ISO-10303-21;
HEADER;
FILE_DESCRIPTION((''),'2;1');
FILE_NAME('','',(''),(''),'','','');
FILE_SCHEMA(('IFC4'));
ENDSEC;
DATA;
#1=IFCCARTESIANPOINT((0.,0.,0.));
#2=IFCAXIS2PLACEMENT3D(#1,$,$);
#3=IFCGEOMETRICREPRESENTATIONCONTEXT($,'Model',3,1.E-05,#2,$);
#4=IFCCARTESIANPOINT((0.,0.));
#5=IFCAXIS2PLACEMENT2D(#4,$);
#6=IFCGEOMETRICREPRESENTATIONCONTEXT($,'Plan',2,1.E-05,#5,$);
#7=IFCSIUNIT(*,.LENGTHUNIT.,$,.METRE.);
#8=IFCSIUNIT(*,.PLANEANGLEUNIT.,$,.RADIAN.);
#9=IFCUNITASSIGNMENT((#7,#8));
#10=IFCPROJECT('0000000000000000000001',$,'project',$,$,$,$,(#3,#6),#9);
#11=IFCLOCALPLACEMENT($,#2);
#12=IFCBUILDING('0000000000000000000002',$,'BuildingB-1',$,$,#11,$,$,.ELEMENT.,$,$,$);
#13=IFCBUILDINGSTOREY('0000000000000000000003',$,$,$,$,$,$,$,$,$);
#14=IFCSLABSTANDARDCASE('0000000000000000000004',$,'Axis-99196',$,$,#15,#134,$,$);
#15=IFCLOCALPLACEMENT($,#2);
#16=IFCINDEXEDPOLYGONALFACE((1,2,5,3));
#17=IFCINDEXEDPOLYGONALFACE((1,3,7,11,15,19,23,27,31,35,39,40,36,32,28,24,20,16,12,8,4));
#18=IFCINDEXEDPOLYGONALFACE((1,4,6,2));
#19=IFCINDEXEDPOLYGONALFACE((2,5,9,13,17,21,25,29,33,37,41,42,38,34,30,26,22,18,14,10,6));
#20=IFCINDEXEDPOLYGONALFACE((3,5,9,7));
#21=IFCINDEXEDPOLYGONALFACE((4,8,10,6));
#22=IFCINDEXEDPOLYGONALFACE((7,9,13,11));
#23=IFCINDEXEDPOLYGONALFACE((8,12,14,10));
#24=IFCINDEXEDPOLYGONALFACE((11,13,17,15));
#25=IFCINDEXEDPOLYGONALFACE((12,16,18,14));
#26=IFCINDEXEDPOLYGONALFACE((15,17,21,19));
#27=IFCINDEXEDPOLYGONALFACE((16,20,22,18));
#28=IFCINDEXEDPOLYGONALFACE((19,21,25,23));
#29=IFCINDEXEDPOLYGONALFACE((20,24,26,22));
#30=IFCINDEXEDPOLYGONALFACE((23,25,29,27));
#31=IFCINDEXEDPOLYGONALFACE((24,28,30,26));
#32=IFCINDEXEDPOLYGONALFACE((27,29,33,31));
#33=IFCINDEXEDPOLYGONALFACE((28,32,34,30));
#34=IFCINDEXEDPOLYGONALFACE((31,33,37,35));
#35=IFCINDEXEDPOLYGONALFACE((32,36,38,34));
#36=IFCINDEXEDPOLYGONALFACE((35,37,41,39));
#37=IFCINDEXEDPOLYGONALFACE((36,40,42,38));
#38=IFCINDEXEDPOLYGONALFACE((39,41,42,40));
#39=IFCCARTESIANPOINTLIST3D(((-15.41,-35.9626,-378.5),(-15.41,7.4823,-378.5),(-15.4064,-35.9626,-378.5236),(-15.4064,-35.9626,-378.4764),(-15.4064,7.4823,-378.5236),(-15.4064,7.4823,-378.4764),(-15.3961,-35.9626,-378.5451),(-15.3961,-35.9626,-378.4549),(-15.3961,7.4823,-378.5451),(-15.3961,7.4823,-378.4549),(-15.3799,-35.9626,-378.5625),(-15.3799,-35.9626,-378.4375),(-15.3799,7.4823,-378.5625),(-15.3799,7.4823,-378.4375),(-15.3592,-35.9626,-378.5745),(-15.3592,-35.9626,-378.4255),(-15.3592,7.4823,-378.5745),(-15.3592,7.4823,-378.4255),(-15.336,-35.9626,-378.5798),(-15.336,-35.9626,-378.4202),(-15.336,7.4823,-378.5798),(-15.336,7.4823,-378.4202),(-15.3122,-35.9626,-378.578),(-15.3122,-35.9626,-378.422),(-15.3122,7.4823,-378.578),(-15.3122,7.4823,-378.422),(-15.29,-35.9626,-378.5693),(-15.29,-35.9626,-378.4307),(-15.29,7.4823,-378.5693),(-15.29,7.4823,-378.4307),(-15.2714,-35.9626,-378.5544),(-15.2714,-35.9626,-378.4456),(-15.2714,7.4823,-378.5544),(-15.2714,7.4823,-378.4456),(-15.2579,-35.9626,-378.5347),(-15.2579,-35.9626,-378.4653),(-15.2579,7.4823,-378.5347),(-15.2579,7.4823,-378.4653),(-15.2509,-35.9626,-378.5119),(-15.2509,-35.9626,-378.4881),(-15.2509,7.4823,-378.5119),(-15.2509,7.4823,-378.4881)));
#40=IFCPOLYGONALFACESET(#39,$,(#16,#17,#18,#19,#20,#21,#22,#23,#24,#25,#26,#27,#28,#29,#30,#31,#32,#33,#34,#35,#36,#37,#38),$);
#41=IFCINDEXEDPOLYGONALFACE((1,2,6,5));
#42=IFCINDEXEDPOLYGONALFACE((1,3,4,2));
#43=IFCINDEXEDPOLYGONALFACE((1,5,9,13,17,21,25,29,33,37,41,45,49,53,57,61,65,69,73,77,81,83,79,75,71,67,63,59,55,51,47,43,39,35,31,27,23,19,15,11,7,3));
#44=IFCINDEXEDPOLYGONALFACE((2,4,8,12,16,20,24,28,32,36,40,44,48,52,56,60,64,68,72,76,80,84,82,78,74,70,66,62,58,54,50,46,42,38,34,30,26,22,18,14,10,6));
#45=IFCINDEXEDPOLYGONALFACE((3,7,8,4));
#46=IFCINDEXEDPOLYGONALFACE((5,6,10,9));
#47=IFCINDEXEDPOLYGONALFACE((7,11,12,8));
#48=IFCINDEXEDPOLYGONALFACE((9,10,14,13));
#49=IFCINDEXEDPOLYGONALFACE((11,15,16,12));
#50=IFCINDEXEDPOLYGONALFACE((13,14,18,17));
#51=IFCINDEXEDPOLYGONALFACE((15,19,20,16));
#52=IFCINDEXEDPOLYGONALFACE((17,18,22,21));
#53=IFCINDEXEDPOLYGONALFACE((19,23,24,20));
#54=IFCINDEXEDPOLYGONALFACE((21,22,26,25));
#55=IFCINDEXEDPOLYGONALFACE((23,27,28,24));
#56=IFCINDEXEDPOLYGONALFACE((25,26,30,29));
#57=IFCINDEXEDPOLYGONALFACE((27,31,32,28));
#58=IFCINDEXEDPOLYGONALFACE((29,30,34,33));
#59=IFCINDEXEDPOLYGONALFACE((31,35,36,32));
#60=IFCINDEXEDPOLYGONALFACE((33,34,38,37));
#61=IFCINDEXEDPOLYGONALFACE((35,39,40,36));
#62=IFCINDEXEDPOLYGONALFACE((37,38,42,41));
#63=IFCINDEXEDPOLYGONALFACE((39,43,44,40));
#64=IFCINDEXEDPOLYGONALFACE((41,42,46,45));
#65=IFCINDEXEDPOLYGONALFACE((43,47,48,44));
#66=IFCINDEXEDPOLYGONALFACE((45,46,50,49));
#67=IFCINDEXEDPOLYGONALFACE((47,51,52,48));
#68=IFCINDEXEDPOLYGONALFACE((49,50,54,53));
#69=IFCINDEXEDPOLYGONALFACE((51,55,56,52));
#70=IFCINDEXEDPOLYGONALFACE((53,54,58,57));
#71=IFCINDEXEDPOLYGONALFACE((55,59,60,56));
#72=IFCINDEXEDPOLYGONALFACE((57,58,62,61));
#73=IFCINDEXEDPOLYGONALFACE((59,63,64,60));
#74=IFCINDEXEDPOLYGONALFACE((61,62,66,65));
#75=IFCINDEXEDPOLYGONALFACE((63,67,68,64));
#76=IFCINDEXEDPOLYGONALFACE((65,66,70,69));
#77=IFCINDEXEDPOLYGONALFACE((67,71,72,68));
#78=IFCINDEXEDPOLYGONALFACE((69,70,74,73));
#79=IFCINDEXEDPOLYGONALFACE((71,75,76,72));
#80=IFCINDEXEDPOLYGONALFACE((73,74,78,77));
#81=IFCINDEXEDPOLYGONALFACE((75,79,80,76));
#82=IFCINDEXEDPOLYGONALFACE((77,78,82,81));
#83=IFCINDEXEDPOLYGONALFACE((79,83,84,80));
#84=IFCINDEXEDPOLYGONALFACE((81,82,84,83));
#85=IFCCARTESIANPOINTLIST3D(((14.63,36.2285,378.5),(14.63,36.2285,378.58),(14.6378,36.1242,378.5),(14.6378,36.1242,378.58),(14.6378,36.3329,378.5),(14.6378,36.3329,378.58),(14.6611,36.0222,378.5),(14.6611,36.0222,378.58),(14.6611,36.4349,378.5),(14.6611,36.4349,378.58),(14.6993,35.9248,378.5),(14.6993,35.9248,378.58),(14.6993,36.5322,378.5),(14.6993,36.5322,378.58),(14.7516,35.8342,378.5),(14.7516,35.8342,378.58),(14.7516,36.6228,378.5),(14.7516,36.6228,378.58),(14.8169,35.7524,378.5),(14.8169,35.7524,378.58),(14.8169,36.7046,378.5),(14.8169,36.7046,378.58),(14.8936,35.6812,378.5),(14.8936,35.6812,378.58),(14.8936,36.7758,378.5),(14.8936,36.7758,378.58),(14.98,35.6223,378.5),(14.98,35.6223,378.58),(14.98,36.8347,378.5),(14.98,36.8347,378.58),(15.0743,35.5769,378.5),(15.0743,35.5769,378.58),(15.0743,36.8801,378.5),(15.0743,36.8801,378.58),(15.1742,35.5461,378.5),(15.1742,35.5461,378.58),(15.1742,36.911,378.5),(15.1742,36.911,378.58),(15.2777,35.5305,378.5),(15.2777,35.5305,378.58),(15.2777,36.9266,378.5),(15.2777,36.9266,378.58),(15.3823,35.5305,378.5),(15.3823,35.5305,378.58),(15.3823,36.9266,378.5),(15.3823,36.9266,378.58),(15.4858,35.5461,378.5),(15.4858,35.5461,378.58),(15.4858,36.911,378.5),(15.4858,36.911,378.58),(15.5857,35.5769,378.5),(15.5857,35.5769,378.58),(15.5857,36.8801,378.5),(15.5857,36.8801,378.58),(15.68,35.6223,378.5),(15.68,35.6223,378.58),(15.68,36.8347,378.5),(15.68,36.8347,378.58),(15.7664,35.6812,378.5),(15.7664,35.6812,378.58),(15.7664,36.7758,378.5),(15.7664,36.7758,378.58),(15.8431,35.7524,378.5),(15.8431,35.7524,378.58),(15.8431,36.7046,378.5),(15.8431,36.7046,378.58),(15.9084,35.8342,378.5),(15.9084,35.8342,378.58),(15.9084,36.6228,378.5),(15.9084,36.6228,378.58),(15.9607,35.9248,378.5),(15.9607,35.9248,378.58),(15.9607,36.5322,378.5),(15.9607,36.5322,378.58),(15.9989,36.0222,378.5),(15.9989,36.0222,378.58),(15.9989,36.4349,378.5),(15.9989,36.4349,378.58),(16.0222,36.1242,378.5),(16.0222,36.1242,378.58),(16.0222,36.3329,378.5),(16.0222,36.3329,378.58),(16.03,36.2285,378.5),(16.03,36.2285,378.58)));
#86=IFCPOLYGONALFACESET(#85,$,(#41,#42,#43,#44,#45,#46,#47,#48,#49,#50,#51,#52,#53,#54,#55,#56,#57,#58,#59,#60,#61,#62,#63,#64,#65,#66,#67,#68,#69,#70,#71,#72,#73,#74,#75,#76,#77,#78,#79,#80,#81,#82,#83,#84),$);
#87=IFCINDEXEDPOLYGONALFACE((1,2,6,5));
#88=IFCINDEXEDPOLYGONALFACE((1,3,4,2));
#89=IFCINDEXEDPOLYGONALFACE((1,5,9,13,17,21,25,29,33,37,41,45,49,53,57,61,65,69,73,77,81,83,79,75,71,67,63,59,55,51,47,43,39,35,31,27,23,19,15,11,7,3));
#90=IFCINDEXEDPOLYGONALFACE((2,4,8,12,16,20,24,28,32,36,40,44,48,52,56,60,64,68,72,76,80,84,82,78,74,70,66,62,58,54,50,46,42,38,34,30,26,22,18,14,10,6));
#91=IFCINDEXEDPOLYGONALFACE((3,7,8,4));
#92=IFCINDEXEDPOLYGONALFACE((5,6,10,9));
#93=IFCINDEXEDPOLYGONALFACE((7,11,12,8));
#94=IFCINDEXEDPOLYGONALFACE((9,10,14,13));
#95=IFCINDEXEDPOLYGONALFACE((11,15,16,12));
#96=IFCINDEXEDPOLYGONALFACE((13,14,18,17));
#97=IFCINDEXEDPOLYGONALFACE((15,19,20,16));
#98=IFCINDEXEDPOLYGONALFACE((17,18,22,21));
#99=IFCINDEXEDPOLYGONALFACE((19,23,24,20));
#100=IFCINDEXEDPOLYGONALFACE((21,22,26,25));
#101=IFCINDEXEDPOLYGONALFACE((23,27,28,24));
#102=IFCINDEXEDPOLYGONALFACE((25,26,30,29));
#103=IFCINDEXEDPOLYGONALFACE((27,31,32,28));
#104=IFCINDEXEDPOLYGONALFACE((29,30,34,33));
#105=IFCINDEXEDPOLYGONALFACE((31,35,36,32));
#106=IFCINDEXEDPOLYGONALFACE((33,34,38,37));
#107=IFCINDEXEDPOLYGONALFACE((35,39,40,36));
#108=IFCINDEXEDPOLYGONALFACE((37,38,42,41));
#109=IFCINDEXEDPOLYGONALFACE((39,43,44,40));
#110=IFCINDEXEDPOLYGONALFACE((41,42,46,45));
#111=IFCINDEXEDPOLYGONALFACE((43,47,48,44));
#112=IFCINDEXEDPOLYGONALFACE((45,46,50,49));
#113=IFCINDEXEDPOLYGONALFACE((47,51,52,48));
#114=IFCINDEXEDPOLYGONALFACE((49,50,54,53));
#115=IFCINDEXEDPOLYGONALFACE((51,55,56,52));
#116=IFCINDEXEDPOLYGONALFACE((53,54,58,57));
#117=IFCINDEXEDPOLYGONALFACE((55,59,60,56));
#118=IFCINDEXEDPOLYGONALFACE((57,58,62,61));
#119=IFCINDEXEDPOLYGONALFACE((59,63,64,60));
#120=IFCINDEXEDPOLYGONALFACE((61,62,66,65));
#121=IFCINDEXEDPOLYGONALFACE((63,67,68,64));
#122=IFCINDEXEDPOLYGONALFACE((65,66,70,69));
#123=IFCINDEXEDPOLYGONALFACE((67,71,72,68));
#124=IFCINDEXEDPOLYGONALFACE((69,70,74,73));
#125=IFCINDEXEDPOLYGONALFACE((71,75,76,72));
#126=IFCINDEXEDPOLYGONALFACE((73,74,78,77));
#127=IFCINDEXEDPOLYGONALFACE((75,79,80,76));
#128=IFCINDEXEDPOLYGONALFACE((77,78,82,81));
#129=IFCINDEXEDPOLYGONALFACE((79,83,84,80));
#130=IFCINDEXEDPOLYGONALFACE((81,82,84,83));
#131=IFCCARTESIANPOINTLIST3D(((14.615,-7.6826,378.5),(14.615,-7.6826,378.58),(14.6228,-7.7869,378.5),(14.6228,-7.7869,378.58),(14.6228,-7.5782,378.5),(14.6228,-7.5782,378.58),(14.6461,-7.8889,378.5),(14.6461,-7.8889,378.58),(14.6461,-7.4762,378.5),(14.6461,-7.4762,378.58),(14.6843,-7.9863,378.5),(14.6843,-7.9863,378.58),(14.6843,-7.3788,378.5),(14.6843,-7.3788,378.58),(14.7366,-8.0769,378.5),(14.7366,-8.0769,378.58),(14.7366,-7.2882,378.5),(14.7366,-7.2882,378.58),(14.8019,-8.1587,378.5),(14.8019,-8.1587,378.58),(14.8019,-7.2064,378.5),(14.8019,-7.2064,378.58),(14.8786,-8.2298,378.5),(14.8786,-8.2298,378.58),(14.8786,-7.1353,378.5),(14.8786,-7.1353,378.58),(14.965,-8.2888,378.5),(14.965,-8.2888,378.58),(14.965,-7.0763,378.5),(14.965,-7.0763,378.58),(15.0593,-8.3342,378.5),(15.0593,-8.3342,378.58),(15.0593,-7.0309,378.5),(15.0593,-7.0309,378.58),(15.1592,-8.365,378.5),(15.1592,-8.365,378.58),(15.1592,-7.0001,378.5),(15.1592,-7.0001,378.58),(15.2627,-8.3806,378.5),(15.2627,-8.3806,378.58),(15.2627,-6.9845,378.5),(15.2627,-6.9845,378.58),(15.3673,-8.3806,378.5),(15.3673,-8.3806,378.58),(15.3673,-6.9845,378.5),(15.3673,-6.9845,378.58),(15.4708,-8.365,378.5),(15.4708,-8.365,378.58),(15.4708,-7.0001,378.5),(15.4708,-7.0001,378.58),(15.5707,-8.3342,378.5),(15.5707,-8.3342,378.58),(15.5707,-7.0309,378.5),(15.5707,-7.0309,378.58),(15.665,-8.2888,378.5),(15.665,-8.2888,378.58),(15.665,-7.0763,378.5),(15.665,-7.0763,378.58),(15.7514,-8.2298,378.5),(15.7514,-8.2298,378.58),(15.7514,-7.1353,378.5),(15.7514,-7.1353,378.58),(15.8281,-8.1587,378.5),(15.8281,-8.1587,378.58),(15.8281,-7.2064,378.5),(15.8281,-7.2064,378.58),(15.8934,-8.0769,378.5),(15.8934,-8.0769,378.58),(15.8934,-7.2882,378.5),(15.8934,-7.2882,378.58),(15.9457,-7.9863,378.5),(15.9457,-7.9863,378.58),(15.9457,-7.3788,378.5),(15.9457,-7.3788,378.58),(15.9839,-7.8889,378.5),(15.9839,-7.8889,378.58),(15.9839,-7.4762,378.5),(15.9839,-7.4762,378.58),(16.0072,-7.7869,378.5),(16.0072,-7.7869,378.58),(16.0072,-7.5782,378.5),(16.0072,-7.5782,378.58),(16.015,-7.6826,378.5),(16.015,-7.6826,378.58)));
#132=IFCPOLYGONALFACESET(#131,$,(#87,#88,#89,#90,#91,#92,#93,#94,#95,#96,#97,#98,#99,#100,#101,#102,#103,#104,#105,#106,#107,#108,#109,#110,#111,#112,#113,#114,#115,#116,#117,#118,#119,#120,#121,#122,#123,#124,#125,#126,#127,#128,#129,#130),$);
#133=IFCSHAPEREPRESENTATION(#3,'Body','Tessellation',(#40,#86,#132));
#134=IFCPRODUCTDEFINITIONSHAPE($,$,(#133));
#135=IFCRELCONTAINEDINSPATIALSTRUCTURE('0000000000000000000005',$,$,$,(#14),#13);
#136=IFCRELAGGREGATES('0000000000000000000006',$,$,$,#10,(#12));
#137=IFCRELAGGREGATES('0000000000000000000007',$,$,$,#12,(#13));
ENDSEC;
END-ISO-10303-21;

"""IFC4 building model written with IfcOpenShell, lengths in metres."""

from ifc_helpers import new_model, entity, si_unit, frame, origin, origin_2d, place, context, project, spatial, circle, extrude, element, save


model = new_model("IFC4")

# Units and contexts
model_context = context("Model", 3, precision=1e-05, world=origin())
plan_context = context("Plan", 2, precision=1e-05, world=origin_2d())
ifc_project = project(units=[si_unit("LENGTHUNIT", "METRE"), si_unit("PLANEANGLEUNIT", "RADIAN")], contexts=[model_context, plan_context])

# Building, storey
building_placement = place(None, origin())
building = spatial("IfcBuilding", under=ifc_project, at=building_placement, Name="BuildingB-1", CompositionType="ELEMENT")
storey = spatial("IfcBuildingStorey", under=building)

# Slab
element("IfcSlabStandardCase", 1, inside=storey, Name="Axis-99196", context=model_context, shape_type="AdvancedSweptSolid", body=[
    entity("IfcSurfaceCurveSweptAreaSolid", entity("IfcCircleProfileDef", "AREA", None, None, 0.08), None, entity("IfcPolyline", [entity("IfcCartesianPoint", [15.33, 35.9626, 378.5]), entity("IfcCartesianPoint", [15.33, -7.4823, 378.5])]), None, None, entity("IfcPlane", entity("IfcAxis2Placement3D", entity("IfcCartesianPoint", [15.33, 35.9626, 378.5]), entity("IfcDirection", [0.0, 0.0, 1.0]), entity("IfcDirection", [1.0, 0.0, 0.0])))),
    extrude(circle(Radius=0.7), frame((15.33, 36.2285, 378.5)), (0.0, 0.0, 1.0), 0.08),
    extrude(circle(Radius=0.7), frame((15.315, -7.6826, 378.5)), (0.0, 0.0, 1.0), 0.08),
])

save(model, "model.ifc")
